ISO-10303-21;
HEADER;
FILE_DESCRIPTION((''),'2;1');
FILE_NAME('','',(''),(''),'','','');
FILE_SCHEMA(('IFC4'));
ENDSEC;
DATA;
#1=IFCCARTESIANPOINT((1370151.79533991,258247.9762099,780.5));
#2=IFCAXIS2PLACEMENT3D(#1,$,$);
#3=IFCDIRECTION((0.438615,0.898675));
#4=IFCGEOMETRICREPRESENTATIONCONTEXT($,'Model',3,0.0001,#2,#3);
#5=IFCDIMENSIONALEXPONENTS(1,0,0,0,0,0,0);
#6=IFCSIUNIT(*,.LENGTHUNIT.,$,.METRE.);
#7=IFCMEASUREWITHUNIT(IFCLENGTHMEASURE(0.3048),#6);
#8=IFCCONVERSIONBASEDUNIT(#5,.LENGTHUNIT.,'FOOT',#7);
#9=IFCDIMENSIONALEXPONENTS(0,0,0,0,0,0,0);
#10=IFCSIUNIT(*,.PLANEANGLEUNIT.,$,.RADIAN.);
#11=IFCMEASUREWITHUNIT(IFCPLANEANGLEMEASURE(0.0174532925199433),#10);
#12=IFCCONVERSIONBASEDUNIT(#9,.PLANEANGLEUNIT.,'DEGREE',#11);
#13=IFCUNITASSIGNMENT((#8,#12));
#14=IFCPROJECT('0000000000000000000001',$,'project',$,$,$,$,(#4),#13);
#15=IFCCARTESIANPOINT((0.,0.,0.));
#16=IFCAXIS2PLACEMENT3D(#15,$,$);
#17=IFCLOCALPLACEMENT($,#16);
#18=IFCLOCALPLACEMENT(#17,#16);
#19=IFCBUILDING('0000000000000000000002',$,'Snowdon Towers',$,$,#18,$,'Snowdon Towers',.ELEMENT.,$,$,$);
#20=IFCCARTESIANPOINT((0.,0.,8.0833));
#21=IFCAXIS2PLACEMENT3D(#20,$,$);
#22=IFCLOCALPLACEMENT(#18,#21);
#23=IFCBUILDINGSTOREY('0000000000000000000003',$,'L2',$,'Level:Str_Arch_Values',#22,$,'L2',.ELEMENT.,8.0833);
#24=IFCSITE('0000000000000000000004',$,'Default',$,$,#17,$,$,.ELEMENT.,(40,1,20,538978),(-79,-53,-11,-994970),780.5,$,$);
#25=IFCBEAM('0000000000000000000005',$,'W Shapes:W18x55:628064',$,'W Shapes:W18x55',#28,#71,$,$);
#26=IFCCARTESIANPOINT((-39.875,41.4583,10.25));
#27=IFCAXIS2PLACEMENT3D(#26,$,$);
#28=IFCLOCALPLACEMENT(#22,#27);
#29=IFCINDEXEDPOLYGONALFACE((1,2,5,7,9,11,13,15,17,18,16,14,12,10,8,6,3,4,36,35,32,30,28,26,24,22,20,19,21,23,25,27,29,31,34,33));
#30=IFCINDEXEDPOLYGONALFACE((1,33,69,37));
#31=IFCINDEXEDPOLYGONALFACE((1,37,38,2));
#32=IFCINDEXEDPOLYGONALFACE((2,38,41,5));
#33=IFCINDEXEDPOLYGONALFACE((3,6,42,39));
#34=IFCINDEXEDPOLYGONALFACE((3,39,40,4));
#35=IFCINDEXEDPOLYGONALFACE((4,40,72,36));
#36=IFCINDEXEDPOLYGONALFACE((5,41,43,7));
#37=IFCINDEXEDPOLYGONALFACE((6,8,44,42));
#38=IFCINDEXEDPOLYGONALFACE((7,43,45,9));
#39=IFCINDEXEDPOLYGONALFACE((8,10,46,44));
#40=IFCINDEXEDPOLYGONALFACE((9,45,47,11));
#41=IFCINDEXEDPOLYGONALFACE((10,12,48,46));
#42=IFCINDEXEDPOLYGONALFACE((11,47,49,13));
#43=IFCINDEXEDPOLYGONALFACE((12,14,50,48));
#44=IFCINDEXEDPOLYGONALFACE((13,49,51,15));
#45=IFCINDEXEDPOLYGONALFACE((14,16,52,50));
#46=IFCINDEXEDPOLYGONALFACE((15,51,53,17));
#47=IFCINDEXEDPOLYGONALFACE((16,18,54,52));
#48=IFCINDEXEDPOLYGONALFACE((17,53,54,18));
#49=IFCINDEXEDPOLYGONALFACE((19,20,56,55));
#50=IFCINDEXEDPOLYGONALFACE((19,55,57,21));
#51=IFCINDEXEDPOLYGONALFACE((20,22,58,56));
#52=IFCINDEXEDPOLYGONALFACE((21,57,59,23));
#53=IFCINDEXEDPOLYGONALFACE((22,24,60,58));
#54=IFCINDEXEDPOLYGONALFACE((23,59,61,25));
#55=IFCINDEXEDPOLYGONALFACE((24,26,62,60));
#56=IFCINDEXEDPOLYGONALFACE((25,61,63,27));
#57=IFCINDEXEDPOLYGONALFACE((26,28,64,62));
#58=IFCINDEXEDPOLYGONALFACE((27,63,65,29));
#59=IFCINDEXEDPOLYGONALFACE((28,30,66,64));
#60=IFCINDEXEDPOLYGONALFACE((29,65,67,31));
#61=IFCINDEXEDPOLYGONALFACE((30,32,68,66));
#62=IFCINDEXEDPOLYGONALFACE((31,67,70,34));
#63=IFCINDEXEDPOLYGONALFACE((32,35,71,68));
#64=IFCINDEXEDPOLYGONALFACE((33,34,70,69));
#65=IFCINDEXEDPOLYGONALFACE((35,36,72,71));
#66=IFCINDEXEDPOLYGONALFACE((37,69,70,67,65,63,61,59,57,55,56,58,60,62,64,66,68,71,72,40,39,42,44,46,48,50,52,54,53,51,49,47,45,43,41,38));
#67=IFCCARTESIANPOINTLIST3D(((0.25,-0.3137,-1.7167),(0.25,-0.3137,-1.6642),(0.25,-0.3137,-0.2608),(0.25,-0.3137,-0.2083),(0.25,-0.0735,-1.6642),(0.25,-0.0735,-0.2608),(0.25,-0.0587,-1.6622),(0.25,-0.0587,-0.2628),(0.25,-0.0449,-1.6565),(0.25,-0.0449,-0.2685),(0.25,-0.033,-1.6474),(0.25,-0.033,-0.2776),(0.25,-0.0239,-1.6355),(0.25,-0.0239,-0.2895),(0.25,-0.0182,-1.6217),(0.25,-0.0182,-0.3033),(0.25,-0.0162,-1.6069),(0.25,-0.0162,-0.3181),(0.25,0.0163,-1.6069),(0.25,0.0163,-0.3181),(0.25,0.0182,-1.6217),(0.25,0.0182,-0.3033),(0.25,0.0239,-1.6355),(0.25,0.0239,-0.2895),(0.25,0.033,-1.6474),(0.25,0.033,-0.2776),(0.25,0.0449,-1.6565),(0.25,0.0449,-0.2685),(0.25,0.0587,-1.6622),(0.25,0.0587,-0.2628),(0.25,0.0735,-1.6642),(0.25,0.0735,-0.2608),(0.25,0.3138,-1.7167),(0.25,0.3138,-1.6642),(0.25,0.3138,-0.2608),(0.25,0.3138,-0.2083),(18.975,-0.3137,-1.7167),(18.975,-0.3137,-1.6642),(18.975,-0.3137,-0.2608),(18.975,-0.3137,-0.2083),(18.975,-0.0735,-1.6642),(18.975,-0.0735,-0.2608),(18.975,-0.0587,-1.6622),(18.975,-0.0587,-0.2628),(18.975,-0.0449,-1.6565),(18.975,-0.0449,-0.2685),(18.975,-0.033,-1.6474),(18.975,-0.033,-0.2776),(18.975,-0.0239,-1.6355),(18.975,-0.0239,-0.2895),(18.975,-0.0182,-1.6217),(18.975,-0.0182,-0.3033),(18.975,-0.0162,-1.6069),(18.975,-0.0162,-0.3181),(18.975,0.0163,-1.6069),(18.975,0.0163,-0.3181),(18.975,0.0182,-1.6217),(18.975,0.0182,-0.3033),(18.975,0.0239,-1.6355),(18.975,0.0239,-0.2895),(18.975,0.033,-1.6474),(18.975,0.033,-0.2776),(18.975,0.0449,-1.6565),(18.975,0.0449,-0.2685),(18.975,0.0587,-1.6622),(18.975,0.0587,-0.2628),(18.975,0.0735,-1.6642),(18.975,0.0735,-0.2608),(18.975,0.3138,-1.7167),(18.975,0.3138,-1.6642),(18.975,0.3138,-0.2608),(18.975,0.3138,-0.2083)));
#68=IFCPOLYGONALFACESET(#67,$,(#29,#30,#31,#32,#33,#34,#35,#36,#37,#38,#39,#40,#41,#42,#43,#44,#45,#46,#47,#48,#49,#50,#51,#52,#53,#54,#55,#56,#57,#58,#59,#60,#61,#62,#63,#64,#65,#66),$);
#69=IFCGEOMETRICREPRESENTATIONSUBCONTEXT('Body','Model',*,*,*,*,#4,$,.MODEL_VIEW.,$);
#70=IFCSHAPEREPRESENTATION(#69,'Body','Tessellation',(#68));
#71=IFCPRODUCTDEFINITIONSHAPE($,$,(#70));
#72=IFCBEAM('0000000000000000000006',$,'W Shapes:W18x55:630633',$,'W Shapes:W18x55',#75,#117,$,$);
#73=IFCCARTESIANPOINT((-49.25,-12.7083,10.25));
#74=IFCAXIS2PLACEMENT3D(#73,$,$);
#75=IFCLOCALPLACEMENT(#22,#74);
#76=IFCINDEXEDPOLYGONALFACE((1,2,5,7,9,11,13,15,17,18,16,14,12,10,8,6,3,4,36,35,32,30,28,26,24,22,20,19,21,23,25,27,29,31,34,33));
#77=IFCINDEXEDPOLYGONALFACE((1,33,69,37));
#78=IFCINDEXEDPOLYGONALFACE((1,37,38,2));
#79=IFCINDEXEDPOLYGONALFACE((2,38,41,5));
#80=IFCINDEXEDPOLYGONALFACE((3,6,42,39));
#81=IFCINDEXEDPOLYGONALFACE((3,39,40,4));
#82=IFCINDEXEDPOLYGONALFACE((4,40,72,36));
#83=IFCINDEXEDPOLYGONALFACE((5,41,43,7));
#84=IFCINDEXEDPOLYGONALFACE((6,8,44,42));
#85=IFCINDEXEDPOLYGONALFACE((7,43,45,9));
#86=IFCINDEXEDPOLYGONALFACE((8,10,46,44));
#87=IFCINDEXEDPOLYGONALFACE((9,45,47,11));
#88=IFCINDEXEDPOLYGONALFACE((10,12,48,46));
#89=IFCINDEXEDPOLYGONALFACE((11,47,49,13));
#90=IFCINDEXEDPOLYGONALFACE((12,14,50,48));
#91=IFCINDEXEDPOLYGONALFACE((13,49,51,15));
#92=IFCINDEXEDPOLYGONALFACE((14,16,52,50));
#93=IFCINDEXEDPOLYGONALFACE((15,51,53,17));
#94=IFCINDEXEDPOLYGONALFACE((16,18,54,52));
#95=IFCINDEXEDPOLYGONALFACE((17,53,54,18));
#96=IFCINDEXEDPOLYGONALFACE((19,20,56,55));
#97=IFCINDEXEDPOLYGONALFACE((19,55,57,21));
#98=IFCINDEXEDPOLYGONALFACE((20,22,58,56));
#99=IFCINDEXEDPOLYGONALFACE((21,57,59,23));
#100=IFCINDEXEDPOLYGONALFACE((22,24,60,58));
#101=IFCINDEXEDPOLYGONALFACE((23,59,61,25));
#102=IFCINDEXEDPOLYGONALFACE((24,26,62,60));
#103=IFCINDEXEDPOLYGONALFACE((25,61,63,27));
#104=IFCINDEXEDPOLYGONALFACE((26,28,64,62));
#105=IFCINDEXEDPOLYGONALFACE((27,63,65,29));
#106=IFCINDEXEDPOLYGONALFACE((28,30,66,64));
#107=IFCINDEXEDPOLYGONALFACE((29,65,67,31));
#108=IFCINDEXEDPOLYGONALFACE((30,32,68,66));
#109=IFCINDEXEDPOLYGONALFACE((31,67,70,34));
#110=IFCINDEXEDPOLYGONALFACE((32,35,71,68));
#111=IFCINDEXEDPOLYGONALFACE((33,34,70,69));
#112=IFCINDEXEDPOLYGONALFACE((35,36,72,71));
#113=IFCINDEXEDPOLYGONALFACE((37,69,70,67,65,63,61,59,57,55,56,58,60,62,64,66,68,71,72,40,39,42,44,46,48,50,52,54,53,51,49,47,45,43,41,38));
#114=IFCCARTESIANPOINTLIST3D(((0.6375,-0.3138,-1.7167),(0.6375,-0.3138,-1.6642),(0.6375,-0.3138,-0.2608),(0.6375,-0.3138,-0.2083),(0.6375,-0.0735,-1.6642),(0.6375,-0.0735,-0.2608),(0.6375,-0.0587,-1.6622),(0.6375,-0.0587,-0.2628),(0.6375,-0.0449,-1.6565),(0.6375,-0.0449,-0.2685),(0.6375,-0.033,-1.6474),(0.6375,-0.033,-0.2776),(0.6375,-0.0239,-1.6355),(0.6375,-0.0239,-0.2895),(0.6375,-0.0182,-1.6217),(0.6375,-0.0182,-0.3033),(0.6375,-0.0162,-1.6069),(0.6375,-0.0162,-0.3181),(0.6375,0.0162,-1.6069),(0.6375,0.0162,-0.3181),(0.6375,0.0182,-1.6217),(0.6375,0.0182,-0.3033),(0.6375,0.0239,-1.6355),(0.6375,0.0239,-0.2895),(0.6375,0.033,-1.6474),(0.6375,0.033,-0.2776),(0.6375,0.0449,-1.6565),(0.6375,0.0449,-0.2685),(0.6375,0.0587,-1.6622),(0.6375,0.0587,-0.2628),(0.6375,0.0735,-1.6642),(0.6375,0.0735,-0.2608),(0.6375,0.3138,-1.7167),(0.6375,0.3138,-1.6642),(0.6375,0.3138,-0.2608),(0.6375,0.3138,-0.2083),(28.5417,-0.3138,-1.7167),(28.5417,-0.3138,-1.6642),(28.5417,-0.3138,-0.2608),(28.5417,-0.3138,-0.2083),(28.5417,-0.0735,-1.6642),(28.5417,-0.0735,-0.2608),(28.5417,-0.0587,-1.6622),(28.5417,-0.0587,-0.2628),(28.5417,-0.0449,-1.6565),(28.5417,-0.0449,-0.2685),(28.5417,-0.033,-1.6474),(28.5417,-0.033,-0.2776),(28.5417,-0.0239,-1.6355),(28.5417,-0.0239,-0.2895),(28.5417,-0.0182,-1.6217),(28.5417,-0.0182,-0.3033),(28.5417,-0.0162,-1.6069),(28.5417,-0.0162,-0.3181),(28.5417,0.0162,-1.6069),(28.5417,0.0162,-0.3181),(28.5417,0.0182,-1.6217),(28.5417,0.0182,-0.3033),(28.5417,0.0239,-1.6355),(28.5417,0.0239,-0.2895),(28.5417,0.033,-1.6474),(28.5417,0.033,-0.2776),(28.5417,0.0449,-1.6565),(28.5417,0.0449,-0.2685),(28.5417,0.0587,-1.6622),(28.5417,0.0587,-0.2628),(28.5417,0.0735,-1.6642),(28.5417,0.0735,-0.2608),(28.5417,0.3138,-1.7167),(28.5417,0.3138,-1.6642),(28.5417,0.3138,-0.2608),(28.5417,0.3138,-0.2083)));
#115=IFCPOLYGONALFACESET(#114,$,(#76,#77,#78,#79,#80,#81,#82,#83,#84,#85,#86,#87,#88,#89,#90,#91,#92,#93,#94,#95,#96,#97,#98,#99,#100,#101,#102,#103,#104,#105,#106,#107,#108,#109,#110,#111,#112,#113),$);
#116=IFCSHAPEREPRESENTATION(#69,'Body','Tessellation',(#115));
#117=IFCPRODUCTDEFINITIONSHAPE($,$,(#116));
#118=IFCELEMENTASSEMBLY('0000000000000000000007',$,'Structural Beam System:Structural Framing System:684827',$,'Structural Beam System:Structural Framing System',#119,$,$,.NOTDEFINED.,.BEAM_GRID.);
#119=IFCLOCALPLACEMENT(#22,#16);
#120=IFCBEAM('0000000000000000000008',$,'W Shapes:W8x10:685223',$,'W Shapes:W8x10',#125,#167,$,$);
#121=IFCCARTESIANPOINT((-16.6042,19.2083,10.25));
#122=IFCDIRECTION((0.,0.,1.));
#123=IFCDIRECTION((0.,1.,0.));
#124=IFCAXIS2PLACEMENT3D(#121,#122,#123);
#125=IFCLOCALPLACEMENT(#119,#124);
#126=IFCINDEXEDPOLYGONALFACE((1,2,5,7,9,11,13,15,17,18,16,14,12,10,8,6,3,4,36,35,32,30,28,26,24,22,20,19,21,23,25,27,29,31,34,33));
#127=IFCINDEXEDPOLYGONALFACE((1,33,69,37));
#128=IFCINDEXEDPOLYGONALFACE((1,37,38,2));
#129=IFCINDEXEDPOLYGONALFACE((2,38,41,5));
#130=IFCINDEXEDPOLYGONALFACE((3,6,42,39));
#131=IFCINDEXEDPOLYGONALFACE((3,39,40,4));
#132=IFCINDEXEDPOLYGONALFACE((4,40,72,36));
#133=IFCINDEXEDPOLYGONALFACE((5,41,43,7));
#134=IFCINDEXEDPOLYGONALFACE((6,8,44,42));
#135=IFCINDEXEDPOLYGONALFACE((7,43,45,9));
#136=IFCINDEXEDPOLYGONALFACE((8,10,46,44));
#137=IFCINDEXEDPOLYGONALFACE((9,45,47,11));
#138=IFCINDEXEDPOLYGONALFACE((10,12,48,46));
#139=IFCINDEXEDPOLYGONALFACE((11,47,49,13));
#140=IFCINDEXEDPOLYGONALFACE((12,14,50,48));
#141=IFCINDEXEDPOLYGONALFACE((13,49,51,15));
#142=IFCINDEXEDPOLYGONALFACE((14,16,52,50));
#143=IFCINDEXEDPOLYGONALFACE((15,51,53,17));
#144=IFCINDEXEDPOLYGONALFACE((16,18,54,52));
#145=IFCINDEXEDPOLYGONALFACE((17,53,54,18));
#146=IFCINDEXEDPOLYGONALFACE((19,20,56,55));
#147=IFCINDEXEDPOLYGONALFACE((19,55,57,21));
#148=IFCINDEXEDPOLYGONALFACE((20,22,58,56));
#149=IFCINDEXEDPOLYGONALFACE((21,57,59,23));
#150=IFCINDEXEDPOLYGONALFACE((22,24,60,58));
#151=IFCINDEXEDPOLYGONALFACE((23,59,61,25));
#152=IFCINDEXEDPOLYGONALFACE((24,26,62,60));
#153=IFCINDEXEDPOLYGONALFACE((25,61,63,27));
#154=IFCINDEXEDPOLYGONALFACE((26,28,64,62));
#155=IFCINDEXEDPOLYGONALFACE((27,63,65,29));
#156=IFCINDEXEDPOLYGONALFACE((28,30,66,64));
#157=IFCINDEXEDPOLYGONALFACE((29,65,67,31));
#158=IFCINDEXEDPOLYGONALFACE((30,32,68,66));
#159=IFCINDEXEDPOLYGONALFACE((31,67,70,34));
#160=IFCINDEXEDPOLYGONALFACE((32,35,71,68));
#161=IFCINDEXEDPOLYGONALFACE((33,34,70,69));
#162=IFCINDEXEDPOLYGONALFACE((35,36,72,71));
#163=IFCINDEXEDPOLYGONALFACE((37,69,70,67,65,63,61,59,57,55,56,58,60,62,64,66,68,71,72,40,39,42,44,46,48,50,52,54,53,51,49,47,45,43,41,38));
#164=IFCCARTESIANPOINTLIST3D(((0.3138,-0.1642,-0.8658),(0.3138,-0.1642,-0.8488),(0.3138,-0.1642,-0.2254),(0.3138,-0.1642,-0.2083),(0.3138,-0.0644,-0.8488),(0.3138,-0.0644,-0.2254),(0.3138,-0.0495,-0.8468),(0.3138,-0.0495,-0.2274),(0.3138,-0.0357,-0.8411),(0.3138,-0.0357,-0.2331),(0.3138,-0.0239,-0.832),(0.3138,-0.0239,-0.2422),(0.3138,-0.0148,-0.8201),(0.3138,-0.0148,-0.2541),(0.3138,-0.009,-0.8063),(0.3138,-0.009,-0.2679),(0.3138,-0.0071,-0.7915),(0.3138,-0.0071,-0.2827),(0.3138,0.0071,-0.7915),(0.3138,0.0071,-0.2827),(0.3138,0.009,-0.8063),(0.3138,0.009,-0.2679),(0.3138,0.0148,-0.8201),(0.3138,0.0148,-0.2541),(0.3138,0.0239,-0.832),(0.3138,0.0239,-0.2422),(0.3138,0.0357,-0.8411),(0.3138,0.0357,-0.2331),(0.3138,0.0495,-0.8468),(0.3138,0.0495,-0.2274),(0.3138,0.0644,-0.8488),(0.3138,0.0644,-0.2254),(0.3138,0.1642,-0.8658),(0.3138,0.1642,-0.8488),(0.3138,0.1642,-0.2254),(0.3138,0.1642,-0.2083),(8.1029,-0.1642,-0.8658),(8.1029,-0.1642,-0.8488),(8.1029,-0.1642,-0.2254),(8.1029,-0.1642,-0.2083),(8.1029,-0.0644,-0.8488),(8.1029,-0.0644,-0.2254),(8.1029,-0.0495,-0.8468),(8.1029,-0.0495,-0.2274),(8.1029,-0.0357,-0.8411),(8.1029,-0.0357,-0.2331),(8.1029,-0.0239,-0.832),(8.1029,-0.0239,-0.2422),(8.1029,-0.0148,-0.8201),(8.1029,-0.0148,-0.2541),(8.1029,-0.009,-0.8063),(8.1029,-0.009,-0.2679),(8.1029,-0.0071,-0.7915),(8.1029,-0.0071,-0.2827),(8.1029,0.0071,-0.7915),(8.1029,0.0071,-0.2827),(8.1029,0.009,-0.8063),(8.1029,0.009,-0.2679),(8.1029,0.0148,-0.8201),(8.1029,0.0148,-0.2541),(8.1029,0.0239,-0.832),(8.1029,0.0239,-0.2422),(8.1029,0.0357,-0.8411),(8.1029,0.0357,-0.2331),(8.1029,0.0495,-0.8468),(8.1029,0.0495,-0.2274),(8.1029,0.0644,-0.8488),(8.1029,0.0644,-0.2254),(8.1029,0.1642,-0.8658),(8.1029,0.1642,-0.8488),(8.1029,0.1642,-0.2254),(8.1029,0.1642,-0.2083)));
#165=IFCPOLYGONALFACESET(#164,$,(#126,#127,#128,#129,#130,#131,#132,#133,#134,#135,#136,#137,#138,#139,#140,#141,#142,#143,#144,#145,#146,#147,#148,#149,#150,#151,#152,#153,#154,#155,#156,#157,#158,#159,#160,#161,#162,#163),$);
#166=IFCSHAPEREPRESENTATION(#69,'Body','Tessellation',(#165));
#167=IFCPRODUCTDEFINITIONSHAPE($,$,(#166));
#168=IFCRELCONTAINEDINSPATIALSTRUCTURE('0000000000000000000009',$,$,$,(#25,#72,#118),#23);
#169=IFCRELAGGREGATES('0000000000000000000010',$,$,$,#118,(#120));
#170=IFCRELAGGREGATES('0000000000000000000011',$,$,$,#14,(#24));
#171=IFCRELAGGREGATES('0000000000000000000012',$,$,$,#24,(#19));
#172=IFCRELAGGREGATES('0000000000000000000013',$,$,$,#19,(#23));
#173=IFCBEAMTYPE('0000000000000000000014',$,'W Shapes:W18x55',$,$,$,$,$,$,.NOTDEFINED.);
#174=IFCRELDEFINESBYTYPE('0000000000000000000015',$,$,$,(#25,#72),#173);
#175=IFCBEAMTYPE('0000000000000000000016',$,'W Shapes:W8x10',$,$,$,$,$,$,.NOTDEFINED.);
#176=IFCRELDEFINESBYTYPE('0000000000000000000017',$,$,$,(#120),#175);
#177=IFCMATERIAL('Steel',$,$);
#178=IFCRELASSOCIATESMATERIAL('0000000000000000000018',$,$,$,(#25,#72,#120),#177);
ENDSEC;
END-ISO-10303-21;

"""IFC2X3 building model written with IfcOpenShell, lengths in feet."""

from ifc_helpers import new_model, entity, si_unit, converted_unit, direction, frame, frame_2d, origin, place, context, subcontext, project, spatial, i_section, extrude, material, type_object, element, aggregate, save


model = new_model("IFC2X3")

# Units and contexts
model_context = context("Model", 3, precision=0.0001, world=frame((1370151.79533991, 258247.9762099, 780.5)), true_north=direction((0.438615, 0.898675)))
body_context = subcontext(model_context, "Body", "Model", "MODEL_VIEW")
ifc_project = project(units=[converted_unit("LENGTHUNIT", "FOOT", entity("IfcLengthMeasure", 0.3048), si_unit("LENGTHUNIT", "METRE"), dimensions=[1, 0, 0, 0, 0, 0, 0]), converted_unit("PLANEANGLEUNIT", "DEGREE", entity("IfcPlaneAngleMeasure", 0.0174532925199433), si_unit("PLANEANGLEUNIT", "RADIAN"), dimensions=[0, 0, 0, 0, 0, 0, 0])], contexts=[model_context])

# Site, building, storey
site_placement = place(None, origin())
site = spatial("IfcSite", under=ifc_project, at=site_placement, Name="Default", CompositionType="ELEMENT", RefLatitude=(40, 1, 20, 538978), RefLongitude=(-79, -53, -11, -994970), RefElevation=780.5)
building_placement = place(site_placement, origin())
building = spatial("IfcBuilding", under=site, at=building_placement, Name="Snowdon Towers", LongName="Snowdon Towers", CompositionType="ELEMENT")
storey_placement = place(building_placement, frame((0.0, 0.0, 8.0833)))
storey = spatial("IfcBuildingStorey", under=building, at=storey_placement, Name="L2", ObjectType="Level:Str_Arch_Values", LongName="L2", CompositionType="ELEMENT", Elevation=8.0833)

# Beams
ifc_material_1 = material(Name="Steel")
beam_type_1 = type_object("IfcBeamType", Name="W Shapes:W18x55", PredefinedType="NOTDEFINED")
beam_1_placement = place(storey_placement, frame((-39.875, 41.4583, 10.25)))
element("IfcBeam", 1, at=beam_1_placement, inside=storey, type_object=beam_type_1, material=ifc_material_1, Name="W Shapes:W18x55:628064", ObjectType="W Shapes:W18x55", context=body_context, shape_type="SweptSolid", body=[
    extrude(i_section(OverallWidth=0.6275, OverallDepth=1.5083, WebThickness=0.0325, FlangeThickness=0.0525, FilletRadius=0.0573, at=frame_2d((0.0, 0.0), x_axis=(0.0, 1.0))), frame((0.25, 0.0, -0.9625), z_axis=(1.0, 0.0, 0.0), x_axis=(0.0, 0.0, -1.0)), (0.0, 0.0, 1.0), 18.725),
])
beam_2_placement = place(storey_placement, frame((-49.25, -12.7083, 10.25)))
element("IfcBeam", 2, at=beam_2_placement, inside=storey, type_object=beam_type_1, material=ifc_material_1, Name="W Shapes:W18x55:630633", ObjectType="W Shapes:W18x55", context=body_context, shape_type="SweptSolid", body=[
    extrude(i_section(OverallWidth=0.6275, OverallDepth=1.5083, WebThickness=0.0325, FlangeThickness=0.0525, FilletRadius=0.0573, at=frame_2d((0.0, 0.0), x_axis=(0.0, 1.0))), frame((0.6375, 0.0, -0.9625), z_axis=(1.0, 0.0, 0.0), x_axis=(0.0, 0.0, -1.0)), (0.0, 0.0, 1.0), 27.9042),
])

# Element assembly, beam
assembly_placement = place(storey_placement, origin())
assembly = element("IfcElementAssembly", 3, at=assembly_placement, inside=storey, Name="Structural Beam System:Structural Framing System:684827", ObjectType="Structural Beam System:Structural Framing System", AssemblyPlace="NOTDEFINED", PredefinedType="BEAM_GRID")
beam_type_2 = type_object("IfcBeamType", Name="W Shapes:W8x10", PredefinedType="NOTDEFINED")
beam_3_placement = place(assembly_placement, frame((-16.6042, 19.2083, 10.25), z_axis=(0.0, 0.0, 1.0), x_axis=(0.0, 1.0, 0.0)))
beam_3 = element("IfcBeam", 4, at=beam_3_placement, type_object=beam_type_2, material=ifc_material_1, Name="W Shapes:W8x10:685223", ObjectType="W Shapes:W8x10", context=body_context, shape_type="SweptSolid", body=[
    extrude(i_section(OverallWidth=0.3283, OverallDepth=0.6575, WebThickness=0.0142, FlangeThickness=0.0171, FilletRadius=0.0573, at=frame_2d((0.0, 0.0), x_axis=(0.0, 1.0))), frame((0.3138, 0.0, -0.5371), z_axis=(1.0, 0.0, 0.0), x_axis=(0.0, 0.0, -1.0)), (0.0, 0.0, 1.0), 7.7892),
])
aggregate(assembly, [beam_3])

save(model, "model.ifc")
